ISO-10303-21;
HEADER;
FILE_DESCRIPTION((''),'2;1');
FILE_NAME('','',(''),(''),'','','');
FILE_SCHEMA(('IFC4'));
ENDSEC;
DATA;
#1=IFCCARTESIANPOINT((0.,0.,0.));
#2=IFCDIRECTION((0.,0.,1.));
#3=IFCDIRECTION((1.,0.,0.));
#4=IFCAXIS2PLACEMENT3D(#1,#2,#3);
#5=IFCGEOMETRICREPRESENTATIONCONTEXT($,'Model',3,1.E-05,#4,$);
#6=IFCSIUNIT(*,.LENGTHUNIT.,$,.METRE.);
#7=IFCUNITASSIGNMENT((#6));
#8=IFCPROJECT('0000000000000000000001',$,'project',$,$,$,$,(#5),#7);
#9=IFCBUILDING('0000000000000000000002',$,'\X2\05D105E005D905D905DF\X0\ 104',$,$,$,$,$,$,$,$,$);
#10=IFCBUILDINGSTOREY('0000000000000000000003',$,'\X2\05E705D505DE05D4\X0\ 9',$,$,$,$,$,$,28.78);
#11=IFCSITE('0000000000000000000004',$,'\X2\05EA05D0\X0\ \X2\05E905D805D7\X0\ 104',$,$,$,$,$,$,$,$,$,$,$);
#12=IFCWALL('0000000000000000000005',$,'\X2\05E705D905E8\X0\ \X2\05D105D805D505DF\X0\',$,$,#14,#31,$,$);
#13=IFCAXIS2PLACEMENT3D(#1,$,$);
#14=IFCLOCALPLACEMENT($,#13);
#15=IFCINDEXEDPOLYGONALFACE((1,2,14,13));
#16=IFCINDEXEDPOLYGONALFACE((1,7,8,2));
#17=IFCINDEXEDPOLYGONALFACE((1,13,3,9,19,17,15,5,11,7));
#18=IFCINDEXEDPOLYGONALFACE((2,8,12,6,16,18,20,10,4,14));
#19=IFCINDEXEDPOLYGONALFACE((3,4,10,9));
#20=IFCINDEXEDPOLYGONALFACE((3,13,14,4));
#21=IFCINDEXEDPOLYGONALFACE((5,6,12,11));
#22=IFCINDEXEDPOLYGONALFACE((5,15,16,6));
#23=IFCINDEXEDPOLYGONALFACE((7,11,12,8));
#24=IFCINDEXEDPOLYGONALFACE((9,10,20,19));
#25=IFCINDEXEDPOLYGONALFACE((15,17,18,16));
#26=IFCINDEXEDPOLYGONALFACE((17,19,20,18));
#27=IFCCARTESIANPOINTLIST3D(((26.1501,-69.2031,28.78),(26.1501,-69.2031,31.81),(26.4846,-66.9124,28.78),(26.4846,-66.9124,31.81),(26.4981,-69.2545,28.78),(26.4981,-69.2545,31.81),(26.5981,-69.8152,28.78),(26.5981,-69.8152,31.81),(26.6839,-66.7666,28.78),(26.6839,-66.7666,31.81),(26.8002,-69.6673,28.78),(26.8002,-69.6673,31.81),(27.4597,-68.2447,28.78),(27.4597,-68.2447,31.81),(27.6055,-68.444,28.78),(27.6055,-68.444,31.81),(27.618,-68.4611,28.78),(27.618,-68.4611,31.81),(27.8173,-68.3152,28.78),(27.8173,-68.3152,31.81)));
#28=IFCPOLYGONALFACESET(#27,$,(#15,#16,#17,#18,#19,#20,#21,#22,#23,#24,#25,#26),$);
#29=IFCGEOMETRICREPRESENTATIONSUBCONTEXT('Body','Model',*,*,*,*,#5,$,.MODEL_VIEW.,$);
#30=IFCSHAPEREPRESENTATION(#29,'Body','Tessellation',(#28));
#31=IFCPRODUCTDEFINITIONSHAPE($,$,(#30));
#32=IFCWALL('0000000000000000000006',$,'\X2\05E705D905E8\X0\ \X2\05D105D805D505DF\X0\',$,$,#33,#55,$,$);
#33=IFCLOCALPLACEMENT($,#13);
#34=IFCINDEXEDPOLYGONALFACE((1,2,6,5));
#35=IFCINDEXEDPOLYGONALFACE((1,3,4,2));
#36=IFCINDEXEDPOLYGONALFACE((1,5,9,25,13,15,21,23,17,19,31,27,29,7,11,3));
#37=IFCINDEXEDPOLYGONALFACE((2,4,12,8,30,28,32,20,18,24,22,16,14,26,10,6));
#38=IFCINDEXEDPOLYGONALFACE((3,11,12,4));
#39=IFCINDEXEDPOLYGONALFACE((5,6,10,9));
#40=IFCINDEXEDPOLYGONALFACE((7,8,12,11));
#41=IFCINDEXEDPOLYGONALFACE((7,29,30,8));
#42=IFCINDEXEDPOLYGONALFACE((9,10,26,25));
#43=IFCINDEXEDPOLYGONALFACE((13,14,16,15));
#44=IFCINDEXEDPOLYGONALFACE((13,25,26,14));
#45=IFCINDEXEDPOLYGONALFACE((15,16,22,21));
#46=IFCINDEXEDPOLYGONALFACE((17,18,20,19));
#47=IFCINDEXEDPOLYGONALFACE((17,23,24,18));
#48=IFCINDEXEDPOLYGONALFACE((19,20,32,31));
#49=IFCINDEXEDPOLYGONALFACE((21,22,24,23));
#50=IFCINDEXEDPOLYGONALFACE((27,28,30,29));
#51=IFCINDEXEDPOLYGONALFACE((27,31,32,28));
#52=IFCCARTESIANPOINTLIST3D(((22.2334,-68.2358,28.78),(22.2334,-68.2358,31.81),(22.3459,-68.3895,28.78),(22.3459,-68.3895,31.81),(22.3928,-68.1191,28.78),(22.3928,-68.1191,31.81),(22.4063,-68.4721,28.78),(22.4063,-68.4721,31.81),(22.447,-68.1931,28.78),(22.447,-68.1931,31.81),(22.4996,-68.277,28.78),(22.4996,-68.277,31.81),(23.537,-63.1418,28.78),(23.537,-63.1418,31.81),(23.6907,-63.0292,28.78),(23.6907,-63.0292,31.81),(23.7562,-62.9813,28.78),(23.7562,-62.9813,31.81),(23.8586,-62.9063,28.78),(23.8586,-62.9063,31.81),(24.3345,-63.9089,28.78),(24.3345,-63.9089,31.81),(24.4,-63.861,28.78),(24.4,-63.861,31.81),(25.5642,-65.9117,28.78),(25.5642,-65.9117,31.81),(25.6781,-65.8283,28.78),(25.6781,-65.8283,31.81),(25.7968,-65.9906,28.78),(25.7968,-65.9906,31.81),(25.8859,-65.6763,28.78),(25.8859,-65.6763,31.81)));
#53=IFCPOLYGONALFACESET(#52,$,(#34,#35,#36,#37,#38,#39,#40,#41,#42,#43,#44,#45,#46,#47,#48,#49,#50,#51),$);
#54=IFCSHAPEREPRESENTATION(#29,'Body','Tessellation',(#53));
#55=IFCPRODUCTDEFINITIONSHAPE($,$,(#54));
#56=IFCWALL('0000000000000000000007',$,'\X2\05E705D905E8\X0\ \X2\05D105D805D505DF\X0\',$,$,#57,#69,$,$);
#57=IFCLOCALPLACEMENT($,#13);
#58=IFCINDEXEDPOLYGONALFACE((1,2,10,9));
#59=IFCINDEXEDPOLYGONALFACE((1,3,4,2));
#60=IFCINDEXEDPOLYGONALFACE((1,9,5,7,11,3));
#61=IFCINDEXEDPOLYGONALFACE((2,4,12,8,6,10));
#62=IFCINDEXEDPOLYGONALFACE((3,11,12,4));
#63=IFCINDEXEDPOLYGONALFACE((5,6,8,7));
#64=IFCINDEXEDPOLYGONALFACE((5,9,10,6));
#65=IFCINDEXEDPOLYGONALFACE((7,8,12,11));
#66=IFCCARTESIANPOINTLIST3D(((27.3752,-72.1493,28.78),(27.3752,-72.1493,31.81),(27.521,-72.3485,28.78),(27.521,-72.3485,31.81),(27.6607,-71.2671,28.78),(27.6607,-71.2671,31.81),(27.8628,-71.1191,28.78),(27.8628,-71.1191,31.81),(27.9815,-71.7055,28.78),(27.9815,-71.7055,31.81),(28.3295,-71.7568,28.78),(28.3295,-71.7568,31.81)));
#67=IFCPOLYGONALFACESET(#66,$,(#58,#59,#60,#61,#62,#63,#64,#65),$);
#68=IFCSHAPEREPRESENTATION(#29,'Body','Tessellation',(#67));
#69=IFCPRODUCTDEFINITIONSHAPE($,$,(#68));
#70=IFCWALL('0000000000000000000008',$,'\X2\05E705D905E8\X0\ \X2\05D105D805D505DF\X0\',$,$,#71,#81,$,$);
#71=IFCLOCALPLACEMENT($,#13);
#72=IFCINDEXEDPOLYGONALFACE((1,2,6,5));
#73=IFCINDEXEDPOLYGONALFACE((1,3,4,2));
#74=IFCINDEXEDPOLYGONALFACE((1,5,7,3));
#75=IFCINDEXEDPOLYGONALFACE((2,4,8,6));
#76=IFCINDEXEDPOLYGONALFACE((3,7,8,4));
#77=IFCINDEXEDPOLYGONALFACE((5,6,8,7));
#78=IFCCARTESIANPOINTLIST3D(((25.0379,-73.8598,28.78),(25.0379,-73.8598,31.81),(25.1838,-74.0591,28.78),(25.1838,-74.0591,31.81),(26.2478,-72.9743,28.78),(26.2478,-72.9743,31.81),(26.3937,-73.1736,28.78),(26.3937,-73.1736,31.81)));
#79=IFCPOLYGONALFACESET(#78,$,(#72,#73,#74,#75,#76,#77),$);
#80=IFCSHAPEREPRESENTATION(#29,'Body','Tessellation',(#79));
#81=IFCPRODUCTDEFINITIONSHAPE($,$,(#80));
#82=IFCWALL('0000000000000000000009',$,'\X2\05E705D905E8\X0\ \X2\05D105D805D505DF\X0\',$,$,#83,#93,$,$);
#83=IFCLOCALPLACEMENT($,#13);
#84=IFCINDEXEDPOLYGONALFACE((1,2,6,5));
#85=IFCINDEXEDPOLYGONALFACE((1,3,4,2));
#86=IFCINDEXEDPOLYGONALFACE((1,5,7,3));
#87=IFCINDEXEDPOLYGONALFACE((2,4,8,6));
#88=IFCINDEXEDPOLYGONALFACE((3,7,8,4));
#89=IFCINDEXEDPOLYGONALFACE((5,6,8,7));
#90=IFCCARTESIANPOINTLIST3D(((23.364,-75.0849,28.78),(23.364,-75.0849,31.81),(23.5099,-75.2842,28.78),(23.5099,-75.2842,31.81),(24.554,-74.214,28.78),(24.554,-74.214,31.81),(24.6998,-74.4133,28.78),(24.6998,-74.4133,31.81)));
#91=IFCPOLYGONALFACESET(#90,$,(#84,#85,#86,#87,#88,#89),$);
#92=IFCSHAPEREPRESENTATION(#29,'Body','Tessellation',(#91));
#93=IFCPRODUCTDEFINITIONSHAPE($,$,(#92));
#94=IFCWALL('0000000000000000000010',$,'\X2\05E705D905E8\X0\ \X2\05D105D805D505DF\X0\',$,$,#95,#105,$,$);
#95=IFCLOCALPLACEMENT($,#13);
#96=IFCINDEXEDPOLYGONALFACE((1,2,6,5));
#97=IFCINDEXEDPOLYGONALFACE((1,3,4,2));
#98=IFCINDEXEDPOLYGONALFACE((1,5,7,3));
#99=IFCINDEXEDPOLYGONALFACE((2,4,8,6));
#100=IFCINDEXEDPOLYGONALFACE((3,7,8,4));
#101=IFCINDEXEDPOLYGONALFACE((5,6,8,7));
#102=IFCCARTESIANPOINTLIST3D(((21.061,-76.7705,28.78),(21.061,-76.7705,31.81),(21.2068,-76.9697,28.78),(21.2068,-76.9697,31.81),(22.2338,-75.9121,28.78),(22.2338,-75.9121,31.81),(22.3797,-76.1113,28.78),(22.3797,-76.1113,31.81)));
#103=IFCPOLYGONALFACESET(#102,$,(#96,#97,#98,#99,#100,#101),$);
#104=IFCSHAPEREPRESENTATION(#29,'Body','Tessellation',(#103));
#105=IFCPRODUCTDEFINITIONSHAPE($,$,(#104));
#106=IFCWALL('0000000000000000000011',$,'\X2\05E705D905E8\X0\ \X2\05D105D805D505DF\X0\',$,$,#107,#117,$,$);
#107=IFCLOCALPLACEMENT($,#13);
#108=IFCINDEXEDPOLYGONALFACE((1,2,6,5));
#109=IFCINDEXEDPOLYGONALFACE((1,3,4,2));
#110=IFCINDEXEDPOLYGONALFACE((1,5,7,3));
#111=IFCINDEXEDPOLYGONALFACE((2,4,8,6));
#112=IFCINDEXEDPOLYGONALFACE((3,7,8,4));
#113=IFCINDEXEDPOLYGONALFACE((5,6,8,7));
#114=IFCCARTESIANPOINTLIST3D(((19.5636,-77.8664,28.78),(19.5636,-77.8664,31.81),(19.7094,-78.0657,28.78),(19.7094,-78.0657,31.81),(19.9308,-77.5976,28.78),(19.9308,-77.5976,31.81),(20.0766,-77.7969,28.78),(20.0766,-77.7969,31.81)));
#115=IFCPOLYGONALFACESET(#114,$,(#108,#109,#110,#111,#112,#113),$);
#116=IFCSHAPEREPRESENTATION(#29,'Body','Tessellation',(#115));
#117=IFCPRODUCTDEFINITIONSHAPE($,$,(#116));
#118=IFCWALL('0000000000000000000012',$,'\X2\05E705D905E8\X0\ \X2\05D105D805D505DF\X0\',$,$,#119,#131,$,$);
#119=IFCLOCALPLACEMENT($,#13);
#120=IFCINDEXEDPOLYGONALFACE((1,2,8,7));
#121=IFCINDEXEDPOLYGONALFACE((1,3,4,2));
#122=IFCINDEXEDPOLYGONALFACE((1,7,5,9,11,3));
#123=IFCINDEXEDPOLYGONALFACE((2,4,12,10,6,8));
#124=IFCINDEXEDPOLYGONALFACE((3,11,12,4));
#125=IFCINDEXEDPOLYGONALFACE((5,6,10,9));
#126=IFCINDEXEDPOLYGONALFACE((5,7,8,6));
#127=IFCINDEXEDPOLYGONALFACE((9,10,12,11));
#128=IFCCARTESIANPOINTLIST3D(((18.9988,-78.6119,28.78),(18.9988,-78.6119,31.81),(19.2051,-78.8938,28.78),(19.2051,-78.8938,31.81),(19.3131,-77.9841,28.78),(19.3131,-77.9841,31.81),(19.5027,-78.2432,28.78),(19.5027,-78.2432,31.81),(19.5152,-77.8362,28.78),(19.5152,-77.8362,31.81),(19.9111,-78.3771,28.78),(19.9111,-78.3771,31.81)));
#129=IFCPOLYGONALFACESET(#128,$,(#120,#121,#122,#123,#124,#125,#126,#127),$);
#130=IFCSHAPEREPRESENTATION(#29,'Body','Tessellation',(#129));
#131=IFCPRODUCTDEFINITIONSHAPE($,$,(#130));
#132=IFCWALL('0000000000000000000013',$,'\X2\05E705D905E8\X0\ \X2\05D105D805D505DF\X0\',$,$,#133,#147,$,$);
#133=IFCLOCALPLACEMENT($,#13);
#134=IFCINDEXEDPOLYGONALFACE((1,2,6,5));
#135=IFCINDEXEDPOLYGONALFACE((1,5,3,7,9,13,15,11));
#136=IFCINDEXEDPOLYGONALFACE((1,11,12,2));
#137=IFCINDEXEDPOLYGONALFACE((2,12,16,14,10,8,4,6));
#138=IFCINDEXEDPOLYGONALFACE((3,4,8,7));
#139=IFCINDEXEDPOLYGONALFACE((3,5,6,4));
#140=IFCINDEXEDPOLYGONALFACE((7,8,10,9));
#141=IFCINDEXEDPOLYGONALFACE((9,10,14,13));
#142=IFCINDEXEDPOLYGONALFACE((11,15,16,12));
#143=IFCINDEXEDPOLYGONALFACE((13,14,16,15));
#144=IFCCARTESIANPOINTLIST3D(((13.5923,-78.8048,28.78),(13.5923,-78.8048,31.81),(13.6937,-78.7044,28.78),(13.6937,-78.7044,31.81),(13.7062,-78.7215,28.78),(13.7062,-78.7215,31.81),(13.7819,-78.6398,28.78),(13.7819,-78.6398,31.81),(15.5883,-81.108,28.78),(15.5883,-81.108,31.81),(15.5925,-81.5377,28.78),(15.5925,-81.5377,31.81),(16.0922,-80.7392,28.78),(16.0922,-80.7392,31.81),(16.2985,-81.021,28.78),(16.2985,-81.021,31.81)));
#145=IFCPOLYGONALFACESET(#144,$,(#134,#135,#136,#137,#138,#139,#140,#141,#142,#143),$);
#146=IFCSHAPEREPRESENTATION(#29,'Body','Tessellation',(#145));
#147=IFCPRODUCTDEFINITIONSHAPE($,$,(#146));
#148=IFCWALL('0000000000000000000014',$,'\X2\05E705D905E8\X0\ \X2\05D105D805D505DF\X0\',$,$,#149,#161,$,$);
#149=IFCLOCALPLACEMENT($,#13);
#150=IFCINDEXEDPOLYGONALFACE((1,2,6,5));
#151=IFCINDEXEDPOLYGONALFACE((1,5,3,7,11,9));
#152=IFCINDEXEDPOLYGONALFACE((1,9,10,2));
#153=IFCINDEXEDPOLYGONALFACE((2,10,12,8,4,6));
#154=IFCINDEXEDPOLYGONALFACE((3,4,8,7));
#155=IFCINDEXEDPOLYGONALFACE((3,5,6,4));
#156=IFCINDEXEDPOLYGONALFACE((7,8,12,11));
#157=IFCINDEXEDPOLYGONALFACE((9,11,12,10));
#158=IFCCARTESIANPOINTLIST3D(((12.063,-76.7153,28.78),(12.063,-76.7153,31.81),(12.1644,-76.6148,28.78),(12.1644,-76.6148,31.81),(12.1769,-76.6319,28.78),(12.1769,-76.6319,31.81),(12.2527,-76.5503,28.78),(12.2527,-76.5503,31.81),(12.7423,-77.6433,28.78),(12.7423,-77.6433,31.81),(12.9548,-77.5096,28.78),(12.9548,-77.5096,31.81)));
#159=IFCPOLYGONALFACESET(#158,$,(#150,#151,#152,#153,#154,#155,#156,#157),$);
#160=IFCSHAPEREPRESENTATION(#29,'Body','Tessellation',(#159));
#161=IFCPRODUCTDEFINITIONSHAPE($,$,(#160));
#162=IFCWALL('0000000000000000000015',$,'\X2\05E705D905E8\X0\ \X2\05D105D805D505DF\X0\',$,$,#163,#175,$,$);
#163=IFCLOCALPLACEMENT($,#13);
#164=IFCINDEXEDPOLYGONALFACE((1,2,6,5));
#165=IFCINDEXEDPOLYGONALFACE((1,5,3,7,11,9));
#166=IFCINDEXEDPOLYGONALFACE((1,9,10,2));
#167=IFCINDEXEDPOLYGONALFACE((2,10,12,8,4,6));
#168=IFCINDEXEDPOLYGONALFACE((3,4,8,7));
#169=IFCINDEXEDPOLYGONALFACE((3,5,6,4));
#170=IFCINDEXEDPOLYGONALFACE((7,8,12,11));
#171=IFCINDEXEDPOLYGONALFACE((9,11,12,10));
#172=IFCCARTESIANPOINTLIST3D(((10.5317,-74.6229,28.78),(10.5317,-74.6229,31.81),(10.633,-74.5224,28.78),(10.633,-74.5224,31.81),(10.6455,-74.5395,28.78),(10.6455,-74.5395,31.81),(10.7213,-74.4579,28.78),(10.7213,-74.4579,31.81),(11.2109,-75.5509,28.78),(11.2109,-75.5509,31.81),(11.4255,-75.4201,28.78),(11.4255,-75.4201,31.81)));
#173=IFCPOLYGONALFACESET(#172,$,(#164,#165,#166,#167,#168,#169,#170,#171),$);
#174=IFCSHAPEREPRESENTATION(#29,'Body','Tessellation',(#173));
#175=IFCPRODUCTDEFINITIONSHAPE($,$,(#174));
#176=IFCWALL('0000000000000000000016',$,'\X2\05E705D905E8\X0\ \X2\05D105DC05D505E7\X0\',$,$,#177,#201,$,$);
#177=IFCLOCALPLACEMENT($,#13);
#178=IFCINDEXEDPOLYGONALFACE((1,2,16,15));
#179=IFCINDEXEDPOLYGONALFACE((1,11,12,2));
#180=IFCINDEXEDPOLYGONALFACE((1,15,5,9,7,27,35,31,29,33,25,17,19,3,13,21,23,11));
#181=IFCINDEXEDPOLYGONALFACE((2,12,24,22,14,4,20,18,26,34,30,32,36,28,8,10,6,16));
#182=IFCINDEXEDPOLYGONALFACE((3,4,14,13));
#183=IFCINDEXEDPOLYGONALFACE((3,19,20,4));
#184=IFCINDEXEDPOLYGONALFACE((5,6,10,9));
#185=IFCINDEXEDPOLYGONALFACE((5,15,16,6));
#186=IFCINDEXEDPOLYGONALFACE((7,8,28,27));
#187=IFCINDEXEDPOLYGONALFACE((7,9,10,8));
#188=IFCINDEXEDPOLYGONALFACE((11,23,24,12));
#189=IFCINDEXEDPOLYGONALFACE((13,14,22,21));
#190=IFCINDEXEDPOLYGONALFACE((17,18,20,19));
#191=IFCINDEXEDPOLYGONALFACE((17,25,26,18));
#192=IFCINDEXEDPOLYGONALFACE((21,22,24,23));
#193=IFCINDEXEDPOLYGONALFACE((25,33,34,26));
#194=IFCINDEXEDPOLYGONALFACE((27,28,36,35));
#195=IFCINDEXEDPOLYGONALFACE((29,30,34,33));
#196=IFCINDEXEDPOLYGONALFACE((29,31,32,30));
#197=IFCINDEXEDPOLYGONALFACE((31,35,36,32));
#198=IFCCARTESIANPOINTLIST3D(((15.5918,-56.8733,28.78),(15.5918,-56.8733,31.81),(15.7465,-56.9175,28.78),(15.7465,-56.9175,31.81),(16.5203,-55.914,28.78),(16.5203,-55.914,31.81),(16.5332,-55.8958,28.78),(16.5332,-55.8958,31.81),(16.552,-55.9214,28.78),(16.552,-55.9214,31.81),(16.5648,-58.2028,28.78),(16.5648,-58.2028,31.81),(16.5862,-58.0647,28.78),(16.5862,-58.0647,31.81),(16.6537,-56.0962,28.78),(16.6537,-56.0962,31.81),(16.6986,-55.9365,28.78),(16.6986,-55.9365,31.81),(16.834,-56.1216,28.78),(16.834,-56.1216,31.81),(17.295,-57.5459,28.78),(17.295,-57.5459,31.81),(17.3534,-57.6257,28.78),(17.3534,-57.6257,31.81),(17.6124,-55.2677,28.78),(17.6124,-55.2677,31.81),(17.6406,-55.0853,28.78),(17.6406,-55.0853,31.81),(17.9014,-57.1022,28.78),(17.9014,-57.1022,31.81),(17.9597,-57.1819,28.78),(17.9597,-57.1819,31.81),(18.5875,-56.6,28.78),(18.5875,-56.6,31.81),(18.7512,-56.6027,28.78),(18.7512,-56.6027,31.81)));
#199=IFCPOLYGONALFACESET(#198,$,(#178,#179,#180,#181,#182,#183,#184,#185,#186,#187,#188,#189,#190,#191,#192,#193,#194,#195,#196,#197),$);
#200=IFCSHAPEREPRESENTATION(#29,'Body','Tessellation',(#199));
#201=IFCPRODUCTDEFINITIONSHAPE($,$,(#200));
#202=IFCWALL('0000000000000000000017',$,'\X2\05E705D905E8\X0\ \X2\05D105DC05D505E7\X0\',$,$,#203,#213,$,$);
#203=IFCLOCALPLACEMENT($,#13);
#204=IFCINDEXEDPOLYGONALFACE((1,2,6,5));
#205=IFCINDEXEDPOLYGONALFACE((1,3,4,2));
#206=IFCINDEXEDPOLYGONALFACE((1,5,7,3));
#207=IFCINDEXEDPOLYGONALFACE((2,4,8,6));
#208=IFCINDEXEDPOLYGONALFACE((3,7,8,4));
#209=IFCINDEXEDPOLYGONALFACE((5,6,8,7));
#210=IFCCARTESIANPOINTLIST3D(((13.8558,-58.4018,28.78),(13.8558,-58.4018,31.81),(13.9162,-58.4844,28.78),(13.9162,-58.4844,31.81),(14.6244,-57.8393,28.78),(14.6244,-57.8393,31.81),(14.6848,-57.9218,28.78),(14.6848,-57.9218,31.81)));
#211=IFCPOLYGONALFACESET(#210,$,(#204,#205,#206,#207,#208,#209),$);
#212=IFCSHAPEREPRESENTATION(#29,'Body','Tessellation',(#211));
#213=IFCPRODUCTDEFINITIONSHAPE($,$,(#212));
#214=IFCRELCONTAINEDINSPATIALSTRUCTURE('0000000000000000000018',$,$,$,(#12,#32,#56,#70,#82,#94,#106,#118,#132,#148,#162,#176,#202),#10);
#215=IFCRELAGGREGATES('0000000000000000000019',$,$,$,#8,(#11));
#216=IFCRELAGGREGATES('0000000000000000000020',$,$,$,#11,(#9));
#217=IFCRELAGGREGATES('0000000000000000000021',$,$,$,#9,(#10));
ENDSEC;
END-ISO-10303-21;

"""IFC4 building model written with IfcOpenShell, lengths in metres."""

from ifc_helpers import new_model, si_unit, frame, origin_with_axes, context, subcontext, project, spatial, polyline, outline, extrude, element, save


model = new_model("IFC4")

# Units and contexts
model_context = context("Model", 3, precision=1e-05, world=origin_with_axes())
body_context = subcontext(model_context, "Body", "Model", "MODEL_VIEW")
ifc_project = project(units=[si_unit("LENGTHUNIT", "METRE")], contexts=[model_context])

# Site, building, storey
site = spatial("IfcSite", under=ifc_project, Name="תא שטח 104")
building = spatial("IfcBuilding", under=site, Name="בניין 104")
storey = spatial("IfcBuildingStorey", under=building, Name="קומה 9", Elevation=28.78)

# Walls
element("IfcWall", 1, inside=storey, Name="קיר בטון", context=body_context, shape_type="SweptSolid", body=[
    extrude(outline(polyline([(27.4597, -68.2447), (26.1501, -69.2031), (26.5981, -69.8152), (26.8002, -69.6673), (26.4981, -69.2545), (27.6055, -68.444), (27.618, -68.4611), (27.8173, -68.3152), (26.6839, -66.7666), (26.4846, -66.9124), (27.4597, -68.2447)])), frame((0.0, 0.0, 28.78)), (0.0, 0.0, 1.0), 3.03),
])
element("IfcWall", 2, inside=storey, Name="קיר בטון", context=body_context, shape_type="SweptSolid", body=[
    extrude(outline(polyline([(23.8586, -62.9063), (23.7562, -62.9813), (24.4, -63.861), (24.3345, -63.9089), (23.6907, -63.0292), (23.537, -63.1418), (25.5642, -65.9117), (22.447, -68.1931), (22.3928, -68.1191), (22.2334, -68.2358), (22.3459, -68.3895), (22.4996, -68.277), (22.4063, -68.4721), (25.7968, -65.9906), (25.6781, -65.8283), (25.8859, -65.6763), (23.8586, -62.9063)])), frame((0.0, 0.0, 28.78)), (0.0, 0.0, 1.0), 3.03),
])
element("IfcWall", 3, inside=storey, Name="קיר בטון", context=body_context, shape_type="SweptSolid", body=[
    extrude(outline(polyline([(27.9815, -71.7055), (27.3752, -72.1493), (27.521, -72.3485), (28.3295, -71.7568), (27.8628, -71.1191), (27.6607, -71.2671), (27.9815, -71.7055)])), frame((0.0, 0.0, 28.78)), (0.0, 0.0, 1.0), 3.03),
])
element("IfcWall", 4, inside=storey, Name="קיר בטון", context=body_context, shape_type="SweptSolid", body=[
    extrude(outline(polyline([(26.2478, -72.9743), (25.0379, -73.8598), (25.1838, -74.0591), (26.3937, -73.1736), (26.2478, -72.9743)])), frame((0.0, 0.0, 28.78)), (0.0, 0.0, 1.0), 3.03),
])
element("IfcWall", 5, inside=storey, Name="קיר בטון", context=body_context, shape_type="SweptSolid", body=[
    extrude(outline(polyline([(23.5099, -75.2842), (24.6998, -74.4133), (24.554, -74.214), (23.364, -75.0849), (23.5099, -75.2842)])), frame((0.0, 0.0, 28.78)), (0.0, 0.0, 1.0), 3.03),
])
element("IfcWall", 6, inside=storey, Name="קיר בטון", context=body_context, shape_type="SweptSolid", body=[
    extrude(outline(polyline([(22.2338, -75.9121), (21.061, -76.7705), (21.2068, -76.9697), (22.3797, -76.1113), (22.2338, -75.9121)])), frame((0.0, 0.0, 28.78)), (0.0, 0.0, 1.0), 3.03),
])
element("IfcWall", 7, inside=storey, Name="קיר בטון", context=body_context, shape_type="SweptSolid", body=[
    extrude(outline(polyline([(19.7094, -78.0657), (20.0766, -77.7969), (19.9308, -77.5976), (19.5636, -77.8664), (19.7094, -78.0657)])), frame((0.0, 0.0, 28.78)), (0.0, 0.0, 1.0), 3.03),
])
element("IfcWall", 8, inside=storey, Name="קיר בטון", context=body_context, shape_type="SweptSolid", body=[
    extrude(outline(polyline([(19.9111, -78.3771), (19.5152, -77.8362), (19.3131, -77.9841), (19.5027, -78.2432), (18.9988, -78.6119), (19.2051, -78.8938), (19.9111, -78.3771)])), frame((0.0, 0.0, 28.78)), (0.0, 0.0, 1.0), 3.03),
])
element("IfcWall", 9, inside=storey, Name="קיר בטון", context=body_context, shape_type="SweptSolid", body=[
    extrude(outline(polyline([(13.7062, -78.7215), (13.5923, -78.8048), (15.5925, -81.5377), (16.2985, -81.021), (16.0922, -80.7392), (15.5883, -81.108), (13.7819, -78.6398), (13.6937, -78.7044), (13.7062, -78.7215)])), frame((0.0, 0.0, 28.78)), (0.0, 0.0, 1.0), 3.03),
])
element("IfcWall", 10, inside=storey, Name="קיר בטון", context=body_context, shape_type="SweptSolid", body=[
    extrude(outline(polyline([(12.1644, -76.6148), (12.1769, -76.6319), (12.063, -76.7153), (12.7423, -77.6433), (12.9548, -77.5096), (12.2527, -76.5503), (12.1644, -76.6148)])), frame((0.0, 0.0, 28.78)), (0.0, 0.0, 1.0), 3.03),
])
element("IfcWall", 11, inside=storey, Name="קיר בטון", context=body_context, shape_type="SweptSolid", body=[
    extrude(outline(polyline([(10.6455, -74.5395), (10.5317, -74.6229), (11.2109, -75.5509), (11.4255, -75.4201), (10.7213, -74.4579), (10.633, -74.5224), (10.6455, -74.5395)])), frame((0.0, 0.0, 28.78)), (0.0, 0.0, 1.0), 3.03),
])
element("IfcWall", 12, inside=storey, Name="קיר בלוק", context=body_context, shape_type="SweptSolid", body=[
    extrude(outline(polyline([(18.7512, -56.6027), (17.6406, -55.0853), (16.5332, -55.8958), (16.552, -55.9214), (16.5203, -55.914), (16.6537, -56.0962), (15.5918, -56.8733), (16.5648, -58.2028), (17.3534, -57.6257), (17.295, -57.5459), (16.5862, -58.0647), (15.7465, -56.9175), (16.834, -56.1216), (16.6986, -55.9365), (17.6124, -55.2677), (18.5875, -56.6), (17.9014, -57.1022), (17.9597, -57.1819), (18.7512, -56.6027)])), frame((0.0, 0.0, 28.78)), (0.0, 0.0, 1.0), 3.03),
])
element("IfcWall", 13, inside=storey, Name="קיר בלוק", context=body_context, shape_type="SweptSolid", body=[
    extrude(outline(polyline([(14.6848, -57.9218), (14.6244, -57.8393), (13.8558, -58.4018), (13.9162, -58.4844), (14.6848, -57.9218)])), frame((0.0, 0.0, 28.78)), (0.0, 0.0, 1.0), 3.03),
])

save(model, "model.ifc")
